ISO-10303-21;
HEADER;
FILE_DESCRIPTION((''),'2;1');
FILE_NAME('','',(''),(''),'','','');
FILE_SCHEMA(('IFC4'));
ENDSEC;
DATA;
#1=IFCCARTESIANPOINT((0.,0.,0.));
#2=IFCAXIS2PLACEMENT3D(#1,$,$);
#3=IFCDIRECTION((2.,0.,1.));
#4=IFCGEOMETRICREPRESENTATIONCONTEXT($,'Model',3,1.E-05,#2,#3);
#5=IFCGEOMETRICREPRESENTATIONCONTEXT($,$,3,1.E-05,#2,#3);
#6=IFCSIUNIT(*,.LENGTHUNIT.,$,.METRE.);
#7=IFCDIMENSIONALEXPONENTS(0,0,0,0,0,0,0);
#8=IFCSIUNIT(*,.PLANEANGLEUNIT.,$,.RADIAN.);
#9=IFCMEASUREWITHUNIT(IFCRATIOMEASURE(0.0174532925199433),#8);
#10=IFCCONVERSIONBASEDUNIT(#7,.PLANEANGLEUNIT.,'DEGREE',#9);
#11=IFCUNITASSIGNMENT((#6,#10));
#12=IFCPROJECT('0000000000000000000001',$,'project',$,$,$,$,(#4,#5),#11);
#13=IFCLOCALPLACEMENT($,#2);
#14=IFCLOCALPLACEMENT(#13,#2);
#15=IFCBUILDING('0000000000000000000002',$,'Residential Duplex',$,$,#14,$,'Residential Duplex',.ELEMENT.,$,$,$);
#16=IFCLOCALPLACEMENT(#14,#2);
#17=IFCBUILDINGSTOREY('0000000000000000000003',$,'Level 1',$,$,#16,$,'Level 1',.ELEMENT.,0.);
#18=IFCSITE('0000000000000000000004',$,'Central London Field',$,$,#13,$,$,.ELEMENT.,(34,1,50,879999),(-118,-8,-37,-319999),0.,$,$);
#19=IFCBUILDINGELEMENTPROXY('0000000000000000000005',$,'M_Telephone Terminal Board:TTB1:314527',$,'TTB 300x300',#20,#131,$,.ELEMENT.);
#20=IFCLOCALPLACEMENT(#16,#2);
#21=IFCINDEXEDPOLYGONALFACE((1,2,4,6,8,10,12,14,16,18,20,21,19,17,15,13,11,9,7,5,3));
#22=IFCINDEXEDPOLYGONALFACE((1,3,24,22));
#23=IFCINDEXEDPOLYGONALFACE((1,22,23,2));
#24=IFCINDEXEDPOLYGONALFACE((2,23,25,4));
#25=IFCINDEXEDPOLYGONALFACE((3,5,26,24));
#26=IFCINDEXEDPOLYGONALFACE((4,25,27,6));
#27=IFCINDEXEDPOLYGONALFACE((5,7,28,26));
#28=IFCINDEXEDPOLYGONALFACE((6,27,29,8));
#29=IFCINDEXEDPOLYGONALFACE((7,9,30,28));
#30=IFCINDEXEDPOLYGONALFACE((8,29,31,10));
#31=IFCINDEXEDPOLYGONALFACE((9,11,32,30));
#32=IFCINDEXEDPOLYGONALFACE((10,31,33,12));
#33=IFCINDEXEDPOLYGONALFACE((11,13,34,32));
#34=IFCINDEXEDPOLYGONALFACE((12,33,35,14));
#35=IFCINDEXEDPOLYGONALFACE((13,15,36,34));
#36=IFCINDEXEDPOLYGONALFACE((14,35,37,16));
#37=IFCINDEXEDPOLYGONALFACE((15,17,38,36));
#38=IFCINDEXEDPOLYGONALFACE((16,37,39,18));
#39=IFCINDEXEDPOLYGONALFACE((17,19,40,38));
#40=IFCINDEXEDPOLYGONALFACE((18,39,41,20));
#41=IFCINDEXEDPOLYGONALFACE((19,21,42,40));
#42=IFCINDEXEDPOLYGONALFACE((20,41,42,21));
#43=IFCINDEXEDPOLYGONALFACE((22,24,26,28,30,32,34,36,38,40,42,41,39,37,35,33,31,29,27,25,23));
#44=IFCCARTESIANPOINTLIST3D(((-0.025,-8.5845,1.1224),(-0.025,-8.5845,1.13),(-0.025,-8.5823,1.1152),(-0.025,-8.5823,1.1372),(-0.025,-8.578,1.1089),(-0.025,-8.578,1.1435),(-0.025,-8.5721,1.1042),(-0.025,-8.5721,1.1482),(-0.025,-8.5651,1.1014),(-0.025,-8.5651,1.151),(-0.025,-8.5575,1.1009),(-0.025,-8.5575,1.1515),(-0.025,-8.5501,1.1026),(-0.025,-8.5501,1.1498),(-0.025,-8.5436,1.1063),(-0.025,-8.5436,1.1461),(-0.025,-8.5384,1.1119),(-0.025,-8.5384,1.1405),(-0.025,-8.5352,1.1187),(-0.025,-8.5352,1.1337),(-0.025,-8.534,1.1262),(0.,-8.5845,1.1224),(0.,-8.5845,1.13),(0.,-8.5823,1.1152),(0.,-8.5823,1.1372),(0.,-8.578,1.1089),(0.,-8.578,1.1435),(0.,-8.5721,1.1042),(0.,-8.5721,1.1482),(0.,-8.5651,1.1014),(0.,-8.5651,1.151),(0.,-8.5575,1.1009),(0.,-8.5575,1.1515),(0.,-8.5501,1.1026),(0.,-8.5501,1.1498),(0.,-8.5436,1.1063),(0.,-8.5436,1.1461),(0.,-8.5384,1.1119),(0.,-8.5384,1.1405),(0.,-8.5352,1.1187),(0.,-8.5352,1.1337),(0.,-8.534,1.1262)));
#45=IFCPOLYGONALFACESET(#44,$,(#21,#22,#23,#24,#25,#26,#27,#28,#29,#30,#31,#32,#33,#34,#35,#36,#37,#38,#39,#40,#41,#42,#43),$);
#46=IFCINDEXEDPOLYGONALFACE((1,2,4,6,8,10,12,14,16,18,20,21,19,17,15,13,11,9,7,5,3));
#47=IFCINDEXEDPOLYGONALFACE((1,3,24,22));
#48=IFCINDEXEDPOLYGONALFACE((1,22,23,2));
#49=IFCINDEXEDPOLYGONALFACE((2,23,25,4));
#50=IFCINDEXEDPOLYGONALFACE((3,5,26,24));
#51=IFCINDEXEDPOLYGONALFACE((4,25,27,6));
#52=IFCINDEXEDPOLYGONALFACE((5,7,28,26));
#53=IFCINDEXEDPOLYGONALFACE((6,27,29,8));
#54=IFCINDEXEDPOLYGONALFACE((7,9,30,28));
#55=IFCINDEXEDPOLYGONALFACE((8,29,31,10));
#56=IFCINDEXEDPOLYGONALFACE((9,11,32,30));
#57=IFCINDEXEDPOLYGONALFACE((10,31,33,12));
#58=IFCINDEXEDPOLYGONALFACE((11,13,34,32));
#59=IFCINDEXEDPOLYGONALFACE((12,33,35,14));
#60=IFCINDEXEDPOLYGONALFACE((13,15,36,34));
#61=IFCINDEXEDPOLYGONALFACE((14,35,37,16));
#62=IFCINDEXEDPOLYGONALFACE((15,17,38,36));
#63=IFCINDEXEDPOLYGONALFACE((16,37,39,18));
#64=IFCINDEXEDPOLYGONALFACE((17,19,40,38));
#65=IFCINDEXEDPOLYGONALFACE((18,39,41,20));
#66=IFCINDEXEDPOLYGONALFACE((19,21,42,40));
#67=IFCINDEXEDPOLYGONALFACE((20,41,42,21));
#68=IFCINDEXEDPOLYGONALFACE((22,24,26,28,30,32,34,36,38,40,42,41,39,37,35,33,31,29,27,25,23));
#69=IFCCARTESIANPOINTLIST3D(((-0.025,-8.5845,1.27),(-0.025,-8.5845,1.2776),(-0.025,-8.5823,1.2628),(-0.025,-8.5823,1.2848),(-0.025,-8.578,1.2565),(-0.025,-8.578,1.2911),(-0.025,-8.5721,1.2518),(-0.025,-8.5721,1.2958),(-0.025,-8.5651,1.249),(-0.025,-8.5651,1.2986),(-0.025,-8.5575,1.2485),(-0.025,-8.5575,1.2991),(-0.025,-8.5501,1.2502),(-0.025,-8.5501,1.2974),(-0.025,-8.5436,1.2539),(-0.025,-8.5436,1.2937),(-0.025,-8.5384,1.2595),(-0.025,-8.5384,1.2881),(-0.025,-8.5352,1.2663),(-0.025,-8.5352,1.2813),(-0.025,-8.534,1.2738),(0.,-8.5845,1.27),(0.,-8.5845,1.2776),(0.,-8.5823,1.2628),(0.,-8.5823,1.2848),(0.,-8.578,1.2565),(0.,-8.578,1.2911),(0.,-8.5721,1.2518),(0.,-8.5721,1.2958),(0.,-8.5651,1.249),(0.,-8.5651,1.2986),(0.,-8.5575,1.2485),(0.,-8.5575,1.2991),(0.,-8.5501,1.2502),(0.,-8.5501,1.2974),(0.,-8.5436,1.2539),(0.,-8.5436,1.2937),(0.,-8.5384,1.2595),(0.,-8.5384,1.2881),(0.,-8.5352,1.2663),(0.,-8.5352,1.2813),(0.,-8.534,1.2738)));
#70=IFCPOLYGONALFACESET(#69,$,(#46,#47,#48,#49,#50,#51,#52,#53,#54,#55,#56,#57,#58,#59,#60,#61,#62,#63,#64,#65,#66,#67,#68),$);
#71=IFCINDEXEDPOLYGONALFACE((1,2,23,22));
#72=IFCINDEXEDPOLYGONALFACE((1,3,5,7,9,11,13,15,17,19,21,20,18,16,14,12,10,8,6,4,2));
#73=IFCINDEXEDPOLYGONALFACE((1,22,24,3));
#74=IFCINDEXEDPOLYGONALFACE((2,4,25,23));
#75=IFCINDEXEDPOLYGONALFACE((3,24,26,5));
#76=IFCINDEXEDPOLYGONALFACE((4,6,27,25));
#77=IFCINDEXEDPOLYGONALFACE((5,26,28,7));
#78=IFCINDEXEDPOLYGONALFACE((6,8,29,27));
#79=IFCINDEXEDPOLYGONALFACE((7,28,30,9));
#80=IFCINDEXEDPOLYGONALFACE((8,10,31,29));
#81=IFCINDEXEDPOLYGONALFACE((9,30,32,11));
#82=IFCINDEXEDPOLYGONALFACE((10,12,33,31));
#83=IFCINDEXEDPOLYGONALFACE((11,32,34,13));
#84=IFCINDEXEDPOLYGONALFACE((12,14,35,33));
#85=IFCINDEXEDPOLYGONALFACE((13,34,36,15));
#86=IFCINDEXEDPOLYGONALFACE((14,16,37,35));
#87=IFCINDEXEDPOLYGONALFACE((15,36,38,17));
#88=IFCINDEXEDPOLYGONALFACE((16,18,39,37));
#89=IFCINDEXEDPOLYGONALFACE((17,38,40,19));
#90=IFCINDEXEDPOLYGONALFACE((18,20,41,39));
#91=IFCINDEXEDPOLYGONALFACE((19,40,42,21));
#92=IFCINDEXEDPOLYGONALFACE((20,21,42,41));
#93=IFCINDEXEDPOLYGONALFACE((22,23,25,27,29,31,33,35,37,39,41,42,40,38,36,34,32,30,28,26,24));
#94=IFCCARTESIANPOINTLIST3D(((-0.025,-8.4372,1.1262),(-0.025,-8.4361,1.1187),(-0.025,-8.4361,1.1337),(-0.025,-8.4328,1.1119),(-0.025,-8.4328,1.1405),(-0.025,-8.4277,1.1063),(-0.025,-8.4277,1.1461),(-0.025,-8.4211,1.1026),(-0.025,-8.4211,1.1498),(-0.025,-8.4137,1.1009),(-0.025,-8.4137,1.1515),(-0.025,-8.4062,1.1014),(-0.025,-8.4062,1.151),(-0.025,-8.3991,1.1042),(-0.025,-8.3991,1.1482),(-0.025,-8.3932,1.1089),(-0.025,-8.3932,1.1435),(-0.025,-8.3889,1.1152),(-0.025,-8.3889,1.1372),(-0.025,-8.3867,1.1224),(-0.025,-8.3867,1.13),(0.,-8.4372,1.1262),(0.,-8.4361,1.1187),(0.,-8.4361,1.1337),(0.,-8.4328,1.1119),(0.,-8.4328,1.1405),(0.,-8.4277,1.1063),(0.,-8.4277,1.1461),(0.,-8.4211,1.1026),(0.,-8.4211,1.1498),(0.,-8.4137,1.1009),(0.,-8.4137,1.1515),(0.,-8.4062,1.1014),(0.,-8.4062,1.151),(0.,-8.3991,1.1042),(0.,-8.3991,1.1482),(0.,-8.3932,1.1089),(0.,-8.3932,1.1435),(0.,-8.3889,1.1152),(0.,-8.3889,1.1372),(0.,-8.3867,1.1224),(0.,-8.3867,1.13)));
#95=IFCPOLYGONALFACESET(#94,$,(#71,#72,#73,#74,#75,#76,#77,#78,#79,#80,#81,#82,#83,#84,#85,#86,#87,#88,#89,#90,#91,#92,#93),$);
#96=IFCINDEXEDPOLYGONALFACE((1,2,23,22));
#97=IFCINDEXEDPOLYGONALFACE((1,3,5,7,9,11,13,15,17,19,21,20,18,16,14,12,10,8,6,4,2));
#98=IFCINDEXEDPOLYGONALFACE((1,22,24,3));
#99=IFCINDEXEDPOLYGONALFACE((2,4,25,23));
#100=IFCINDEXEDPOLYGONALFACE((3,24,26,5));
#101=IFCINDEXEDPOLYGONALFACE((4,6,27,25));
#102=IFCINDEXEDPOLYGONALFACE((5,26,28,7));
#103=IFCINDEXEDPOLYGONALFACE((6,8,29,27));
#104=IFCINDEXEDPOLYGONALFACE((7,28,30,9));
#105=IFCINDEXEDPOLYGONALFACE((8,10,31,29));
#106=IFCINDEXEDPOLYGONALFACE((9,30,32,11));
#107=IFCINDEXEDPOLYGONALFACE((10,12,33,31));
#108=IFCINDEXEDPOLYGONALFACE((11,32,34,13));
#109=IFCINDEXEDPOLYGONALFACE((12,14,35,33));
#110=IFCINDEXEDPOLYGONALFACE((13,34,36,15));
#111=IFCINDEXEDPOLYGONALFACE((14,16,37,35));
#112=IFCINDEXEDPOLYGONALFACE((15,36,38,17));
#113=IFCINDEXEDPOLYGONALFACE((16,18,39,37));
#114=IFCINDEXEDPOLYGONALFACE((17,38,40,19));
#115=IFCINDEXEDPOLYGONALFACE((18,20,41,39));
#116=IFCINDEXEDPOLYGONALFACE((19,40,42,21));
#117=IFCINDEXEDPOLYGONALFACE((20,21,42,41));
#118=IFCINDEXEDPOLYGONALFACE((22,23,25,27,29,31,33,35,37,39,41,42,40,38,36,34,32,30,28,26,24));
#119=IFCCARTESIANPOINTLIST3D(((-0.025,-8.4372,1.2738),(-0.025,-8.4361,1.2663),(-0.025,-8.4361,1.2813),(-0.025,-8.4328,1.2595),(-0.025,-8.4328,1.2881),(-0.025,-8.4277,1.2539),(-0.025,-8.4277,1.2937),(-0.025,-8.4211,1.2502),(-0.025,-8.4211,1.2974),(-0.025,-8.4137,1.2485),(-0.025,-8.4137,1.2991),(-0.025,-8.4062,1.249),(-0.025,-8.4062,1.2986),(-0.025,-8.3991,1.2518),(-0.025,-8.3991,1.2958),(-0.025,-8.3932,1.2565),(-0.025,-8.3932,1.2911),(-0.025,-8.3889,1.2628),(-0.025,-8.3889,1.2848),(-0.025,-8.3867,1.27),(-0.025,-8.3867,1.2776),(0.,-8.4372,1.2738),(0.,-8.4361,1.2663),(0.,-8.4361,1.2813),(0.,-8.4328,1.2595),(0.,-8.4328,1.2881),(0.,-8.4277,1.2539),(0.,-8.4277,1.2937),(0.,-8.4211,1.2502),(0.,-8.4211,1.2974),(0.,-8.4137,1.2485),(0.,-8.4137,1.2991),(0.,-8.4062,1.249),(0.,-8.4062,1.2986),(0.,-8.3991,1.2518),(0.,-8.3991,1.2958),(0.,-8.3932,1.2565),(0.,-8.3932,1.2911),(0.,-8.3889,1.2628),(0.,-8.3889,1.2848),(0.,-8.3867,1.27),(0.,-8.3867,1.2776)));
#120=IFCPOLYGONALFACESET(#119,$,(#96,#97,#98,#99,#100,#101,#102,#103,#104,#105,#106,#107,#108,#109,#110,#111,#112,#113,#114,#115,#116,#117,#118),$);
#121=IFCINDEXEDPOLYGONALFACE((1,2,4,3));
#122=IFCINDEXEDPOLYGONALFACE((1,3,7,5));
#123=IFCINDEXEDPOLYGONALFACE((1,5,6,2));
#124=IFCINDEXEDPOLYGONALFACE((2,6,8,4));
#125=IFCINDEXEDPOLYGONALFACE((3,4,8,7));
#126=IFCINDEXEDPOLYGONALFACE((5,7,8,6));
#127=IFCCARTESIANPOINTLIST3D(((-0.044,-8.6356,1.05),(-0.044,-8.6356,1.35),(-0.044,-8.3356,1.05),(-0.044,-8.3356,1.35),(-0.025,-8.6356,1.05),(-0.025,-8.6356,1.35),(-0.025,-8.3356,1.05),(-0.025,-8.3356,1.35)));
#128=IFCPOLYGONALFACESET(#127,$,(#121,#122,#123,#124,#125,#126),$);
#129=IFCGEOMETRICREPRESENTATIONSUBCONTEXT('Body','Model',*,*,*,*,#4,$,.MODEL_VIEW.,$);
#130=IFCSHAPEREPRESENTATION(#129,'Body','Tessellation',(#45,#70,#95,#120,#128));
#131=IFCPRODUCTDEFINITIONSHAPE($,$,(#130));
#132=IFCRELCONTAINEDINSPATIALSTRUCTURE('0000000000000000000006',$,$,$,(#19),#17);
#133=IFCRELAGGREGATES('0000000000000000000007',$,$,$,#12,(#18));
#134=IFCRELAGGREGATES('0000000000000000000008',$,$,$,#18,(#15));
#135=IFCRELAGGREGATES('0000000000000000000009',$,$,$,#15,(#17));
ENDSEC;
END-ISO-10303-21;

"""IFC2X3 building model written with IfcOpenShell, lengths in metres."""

from ifc_helpers import new_model, entity, si_unit, converted_unit, direction, frame, frame_2d, origin, origin_2d_with_axis, place, context, subcontext, project, spatial, rectangle, circle, extrude, source, transform, mapped, element, save


model = new_model("IFC2X3")

# Units and contexts
model_context = context("Model", 3, precision=1e-05, world=origin(), true_north=direction((2.0, 0.0, 1.0)))
context_of_model = context(None, 3, precision=1e-05, world=origin(), true_north=direction((2.0, 0.0, 1.0)))
body_context = subcontext(model_context, "Body", "Model", "MODEL_VIEW")
ifc_project = project(units=[si_unit("LENGTHUNIT", "METRE"), converted_unit("PLANEANGLEUNIT", "DEGREE", entity("IfcRatioMeasure", 0.0174532925199433), si_unit("PLANEANGLEUNIT", "RADIAN"), dimensions=[0, 0, 0, 0, 0, 0, 0])], contexts=[model_context, context_of_model])

# Site, building, storey
site_placement = place(None, origin())
site = spatial("IfcSite", under=ifc_project, at=site_placement, Name="Central London Field", CompositionType="ELEMENT", RefLatitude=(34, 1, 50, 879999), RefLongitude=(-118, -8, -37, -319999), RefElevation=0.0)
building_placement = place(site_placement, origin())
building = spatial("IfcBuilding", under=site, at=building_placement, Name="Residential Duplex", LongName="Residential Duplex", CompositionType="ELEMENT")
storey_placement = place(building_placement, origin())
storey = spatial("IfcBuildingStorey", under=building, at=storey_placement, Name="Level 1", LongName="Level 1", CompositionType="ELEMENT", Elevation=0.0)

# Building element proxy
shared_shape_1 = source(origin(), body_context, "Body", "SweptSolid", [
    extrude(circle(Radius=0.0254, at=frame_2d((0.0, 0.0), x_axis=(1.0, 0.0))), frame((0.0738, -0.0738, 0.0), z_axis=(0.0, 0.0, 1.0), x_axis=(-1.0, 0.0, 0.0)), (0.0, 0.0, 1.0), 0.025),
    extrude(circle(Radius=0.0254, at=frame_2d((0.0, 0.0), x_axis=(1.0, 0.0))), frame((0.0738, 0.0738, 0.0), z_axis=(0.0, 0.0, 1.0), x_axis=(-1.0, 0.0, 0.0)), (0.0, 0.0, 1.0), 0.025),
    extrude(circle(Radius=0.0254, at=frame_2d((0.0, 0.0), x_axis=(1.0, 0.0))), frame((-0.0738, -0.0738, 0.0)), (0.0, 0.0, 1.0), 0.025),
    extrude(circle(Radius=0.0254, at=frame_2d((0.0, 0.0), x_axis=(1.0, 0.0))), frame((-0.0738, 0.0738, 0.0)), (0.0, 0.0, 1.0), 0.025),
    extrude(rectangle(XDim=0.3, YDim=0.3, at=origin_2d_with_axis()), frame((0.0, 0.0, 0.025), z_axis=(0.0, 0.0, 1.0), x_axis=(-1.0, 0.0, 0.0)), (0.0, 0.0, 1.0), 0.019),
])
proxy_1_placement = place(storey_placement, frame((0.0, -8.4856, 1.2), z_axis=(-1.0, 0.0, 0.0), x_axis=(0.0, -1.0, 0.0)))
element("IfcBuildingElementProxy", 1, at=proxy_1_placement, inside=storey, Name="M_Telephone Terminal Board:TTB1:314527", ObjectType="TTB 300x300", CompositionType="ELEMENT", context=body_context, shape_type="MappedRepresentation", body=[
    mapped(shared_shape_1, transform((0.0, 0.0, 0.0), scale=1.0)),
])

save(model, "model.ifc")
